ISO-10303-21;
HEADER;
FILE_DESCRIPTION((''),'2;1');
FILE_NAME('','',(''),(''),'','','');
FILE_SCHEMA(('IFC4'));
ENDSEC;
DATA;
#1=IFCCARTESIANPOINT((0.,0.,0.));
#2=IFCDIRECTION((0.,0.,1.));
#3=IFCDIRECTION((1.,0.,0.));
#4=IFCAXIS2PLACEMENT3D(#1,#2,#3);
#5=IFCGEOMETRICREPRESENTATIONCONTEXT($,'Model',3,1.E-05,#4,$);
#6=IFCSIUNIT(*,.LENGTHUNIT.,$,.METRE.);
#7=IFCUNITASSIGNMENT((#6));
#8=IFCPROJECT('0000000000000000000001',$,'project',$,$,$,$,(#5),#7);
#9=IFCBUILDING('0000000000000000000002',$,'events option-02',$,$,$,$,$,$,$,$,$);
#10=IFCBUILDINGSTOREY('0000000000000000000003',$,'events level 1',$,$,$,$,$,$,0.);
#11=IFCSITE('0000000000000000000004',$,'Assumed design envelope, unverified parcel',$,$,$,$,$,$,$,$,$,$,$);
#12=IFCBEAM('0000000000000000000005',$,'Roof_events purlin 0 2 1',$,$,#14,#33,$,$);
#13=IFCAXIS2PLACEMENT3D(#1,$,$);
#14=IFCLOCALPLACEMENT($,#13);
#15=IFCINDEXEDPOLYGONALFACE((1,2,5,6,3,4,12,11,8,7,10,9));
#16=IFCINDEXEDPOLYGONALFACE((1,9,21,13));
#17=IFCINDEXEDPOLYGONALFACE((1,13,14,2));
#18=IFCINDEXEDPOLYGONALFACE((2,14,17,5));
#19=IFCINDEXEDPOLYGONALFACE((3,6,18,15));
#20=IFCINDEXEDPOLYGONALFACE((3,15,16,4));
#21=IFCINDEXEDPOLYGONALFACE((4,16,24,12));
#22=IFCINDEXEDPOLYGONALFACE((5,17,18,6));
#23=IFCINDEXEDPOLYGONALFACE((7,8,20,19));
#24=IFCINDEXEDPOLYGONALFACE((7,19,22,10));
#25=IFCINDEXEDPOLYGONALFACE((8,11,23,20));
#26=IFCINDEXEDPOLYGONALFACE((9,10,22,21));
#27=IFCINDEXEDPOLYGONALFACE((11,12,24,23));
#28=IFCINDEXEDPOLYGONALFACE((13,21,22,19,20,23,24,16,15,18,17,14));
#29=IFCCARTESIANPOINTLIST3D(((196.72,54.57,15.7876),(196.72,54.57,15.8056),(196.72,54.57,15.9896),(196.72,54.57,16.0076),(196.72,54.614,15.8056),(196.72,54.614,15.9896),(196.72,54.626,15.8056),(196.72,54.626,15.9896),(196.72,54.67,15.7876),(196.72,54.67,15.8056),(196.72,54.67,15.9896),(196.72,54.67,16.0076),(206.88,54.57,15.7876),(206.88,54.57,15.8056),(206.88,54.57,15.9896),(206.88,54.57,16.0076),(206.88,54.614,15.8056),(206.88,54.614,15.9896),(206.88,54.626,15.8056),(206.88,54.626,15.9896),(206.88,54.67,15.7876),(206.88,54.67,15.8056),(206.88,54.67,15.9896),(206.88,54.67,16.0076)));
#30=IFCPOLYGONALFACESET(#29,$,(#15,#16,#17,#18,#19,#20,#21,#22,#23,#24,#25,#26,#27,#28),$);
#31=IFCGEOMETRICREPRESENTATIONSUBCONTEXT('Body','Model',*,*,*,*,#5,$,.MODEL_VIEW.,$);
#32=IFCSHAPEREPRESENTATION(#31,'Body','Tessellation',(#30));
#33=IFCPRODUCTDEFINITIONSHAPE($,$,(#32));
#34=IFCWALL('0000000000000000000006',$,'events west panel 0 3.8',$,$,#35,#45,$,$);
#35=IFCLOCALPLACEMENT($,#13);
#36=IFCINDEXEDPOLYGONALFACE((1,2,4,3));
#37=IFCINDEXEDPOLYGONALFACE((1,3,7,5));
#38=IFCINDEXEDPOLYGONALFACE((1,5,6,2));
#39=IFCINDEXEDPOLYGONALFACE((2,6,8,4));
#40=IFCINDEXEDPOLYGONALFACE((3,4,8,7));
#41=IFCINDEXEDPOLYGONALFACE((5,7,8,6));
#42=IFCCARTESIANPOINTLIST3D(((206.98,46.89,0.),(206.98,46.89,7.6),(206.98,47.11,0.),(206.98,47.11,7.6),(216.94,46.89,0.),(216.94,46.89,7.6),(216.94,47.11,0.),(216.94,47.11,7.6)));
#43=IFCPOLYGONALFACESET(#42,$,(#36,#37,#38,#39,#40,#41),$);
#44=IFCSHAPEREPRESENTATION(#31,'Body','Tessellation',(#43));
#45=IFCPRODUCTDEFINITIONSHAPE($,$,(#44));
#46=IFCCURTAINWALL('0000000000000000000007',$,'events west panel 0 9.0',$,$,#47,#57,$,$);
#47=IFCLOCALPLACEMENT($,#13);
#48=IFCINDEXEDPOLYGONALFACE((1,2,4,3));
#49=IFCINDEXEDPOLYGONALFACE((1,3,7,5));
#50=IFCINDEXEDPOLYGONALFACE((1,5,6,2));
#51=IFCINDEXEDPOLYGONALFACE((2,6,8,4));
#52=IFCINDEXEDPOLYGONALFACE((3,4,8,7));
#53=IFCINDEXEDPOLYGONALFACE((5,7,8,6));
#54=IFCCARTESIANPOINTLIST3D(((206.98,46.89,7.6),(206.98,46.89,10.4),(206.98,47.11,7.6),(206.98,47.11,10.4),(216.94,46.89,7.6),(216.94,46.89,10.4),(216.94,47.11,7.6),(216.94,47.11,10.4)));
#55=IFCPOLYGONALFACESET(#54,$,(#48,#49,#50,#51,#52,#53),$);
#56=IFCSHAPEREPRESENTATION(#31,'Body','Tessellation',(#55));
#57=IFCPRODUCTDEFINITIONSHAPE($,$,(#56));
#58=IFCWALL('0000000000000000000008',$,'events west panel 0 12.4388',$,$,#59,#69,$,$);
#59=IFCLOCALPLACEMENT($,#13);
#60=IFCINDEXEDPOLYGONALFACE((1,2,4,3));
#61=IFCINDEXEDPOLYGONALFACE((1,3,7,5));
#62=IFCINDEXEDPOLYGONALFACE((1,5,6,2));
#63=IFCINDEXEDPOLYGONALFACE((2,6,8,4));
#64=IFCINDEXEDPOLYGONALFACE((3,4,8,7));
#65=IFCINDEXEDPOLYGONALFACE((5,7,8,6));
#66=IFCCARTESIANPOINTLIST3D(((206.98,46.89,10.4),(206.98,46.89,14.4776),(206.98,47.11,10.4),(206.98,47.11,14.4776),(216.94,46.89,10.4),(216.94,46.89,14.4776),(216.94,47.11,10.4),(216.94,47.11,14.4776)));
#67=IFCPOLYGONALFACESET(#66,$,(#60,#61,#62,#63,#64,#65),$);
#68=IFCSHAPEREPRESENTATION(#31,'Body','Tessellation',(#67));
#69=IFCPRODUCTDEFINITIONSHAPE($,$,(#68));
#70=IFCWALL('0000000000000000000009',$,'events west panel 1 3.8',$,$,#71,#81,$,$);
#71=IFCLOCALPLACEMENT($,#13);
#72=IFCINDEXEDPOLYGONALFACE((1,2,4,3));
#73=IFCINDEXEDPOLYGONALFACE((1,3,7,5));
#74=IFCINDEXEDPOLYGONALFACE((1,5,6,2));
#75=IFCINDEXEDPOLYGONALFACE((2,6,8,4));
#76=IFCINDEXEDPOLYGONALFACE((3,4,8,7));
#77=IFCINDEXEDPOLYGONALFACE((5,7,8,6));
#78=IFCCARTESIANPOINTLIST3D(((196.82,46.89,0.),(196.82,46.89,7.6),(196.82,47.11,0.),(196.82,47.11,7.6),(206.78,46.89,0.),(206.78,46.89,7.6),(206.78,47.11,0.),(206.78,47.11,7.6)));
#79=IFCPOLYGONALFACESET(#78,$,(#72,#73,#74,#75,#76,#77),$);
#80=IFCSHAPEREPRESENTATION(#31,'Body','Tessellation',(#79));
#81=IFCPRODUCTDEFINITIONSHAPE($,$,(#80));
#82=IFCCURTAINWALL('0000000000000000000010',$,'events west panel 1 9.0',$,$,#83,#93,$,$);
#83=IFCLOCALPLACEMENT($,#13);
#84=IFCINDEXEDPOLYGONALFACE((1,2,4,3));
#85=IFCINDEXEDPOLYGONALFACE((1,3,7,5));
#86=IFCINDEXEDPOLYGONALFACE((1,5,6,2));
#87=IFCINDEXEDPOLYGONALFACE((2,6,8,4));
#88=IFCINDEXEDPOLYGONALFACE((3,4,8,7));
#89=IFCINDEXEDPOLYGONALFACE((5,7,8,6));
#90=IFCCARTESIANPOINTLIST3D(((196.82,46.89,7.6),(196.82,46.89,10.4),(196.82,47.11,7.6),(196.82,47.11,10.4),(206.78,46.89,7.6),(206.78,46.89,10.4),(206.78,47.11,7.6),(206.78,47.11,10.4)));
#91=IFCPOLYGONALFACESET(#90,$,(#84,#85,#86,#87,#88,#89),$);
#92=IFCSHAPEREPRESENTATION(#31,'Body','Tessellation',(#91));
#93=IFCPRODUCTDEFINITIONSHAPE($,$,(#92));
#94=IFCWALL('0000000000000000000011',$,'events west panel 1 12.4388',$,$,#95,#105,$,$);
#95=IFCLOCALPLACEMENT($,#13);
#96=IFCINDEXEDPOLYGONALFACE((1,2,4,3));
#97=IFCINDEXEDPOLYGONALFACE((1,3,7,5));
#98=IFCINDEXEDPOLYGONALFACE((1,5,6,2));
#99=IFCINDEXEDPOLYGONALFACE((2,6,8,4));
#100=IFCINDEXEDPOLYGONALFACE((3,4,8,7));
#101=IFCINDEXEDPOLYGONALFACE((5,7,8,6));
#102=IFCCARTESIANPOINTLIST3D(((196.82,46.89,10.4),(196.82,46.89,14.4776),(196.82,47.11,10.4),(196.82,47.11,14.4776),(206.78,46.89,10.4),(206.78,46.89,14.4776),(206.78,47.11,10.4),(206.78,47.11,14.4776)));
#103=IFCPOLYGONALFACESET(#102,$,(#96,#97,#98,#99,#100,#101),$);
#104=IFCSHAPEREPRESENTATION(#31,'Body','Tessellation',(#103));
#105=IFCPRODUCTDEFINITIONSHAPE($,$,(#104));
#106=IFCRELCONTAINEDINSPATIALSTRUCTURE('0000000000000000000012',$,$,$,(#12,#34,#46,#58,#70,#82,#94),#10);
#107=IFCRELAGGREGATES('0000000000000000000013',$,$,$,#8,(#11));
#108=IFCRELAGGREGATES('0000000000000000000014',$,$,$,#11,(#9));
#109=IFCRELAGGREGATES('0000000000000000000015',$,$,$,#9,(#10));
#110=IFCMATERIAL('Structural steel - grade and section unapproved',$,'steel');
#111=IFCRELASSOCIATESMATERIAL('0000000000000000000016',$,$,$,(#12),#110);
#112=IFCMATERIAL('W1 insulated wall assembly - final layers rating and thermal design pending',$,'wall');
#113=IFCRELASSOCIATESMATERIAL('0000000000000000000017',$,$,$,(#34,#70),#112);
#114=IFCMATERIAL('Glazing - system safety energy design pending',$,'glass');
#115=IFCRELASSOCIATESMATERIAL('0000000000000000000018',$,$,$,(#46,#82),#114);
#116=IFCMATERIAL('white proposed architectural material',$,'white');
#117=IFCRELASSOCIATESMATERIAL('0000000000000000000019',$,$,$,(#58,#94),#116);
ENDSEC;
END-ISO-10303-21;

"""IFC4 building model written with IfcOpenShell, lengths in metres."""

from ifc_helpers import new_model, si_unit, frame, origin_with_axes, place, context, subcontext, project, spatial, rectangle, i_section, extrude, material, element, save


model = new_model("IFC4")

# Units and contexts
model_context = context("Model", 3, precision=1e-05, world=origin_with_axes())
body_context = subcontext(model_context, "Body", "Model", "MODEL_VIEW")
ifc_project = project(units=[si_unit("LENGTHUNIT", "METRE")], contexts=[model_context])

# Site, building, storey
site = spatial("IfcSite", under=ifc_project, Name="Assumed design envelope, unverified parcel")
building = spatial("IfcBuilding", under=site, Name="events option-02")
storey = spatial("IfcBuildingStorey", under=building, Name="events level 1", Elevation=0.0)

# Shared definitions
ifc_material_1 = material(Name="Structural steel - grade and section unapproved", Category="steel")

# Beam
beam_1_placement = place(None, frame((206.88, 54.62, 15.8976), z_axis=(-1.0, 0.0, 0.0), x_axis=(0.0, -1.0, 0.0)))
element("IfcBeam", 1, at=beam_1_placement, inside=storey, material=ifc_material_1, Name="Roof_events purlin 0 2 1", context=body_context, shape_type="SweptSolid", body=[
    extrude(i_section(OverallWidth=0.1, OverallDepth=0.22, WebThickness=0.012, FlangeThickness=0.018, FilletRadius=0.0), origin_with_axes(), (0.0, 0.0, 1.0), 10.16),
])

# Wall
ifc_material_2 = material(Name="W1 insulated wall assembly - final layers rating and thermal design pending", Category="wall")
wall_1_placement = place(None, frame((211.96, 47.0, 0.0), z_axis=(0.0, 0.0, 1.0), x_axis=(0.0, 1.0, 0.0)))
element("IfcWall", 2, at=wall_1_placement, inside=storey, material=ifc_material_2, Name="events west panel 0 3.8", context=body_context, shape_type="SweptSolid", body=[
    extrude(rectangle(XDim=0.22, YDim=9.96), origin_with_axes(), (0.0, 0.0, 1.0), 7.6),
])

# Curtain wall
ifc_material_3 = material(Name="Glazing - system safety energy design pending", Category="glass")
curtain_wall_1_placement = place(None, frame((211.96, 47.0, 7.6), z_axis=(0.0, 0.0, 1.0), x_axis=(0.0, 1.0, 0.0)))
element("IfcCurtainWall", 3, at=curtain_wall_1_placement, inside=storey, material=ifc_material_3, Name="events west panel 0 9.0", context=body_context, shape_type="SweptSolid", body=[
    extrude(rectangle(XDim=0.22, YDim=9.96), origin_with_axes(), (0.0, 0.0, 1.0), 2.8),
])

# Walls
ifc_material_4 = material(Name="white proposed architectural material", Category="white")
wall_2_placement = place(None, frame((211.96, 47.0, 10.4), z_axis=(0.0, 0.0, 1.0), x_axis=(0.0, 1.0, 0.0)))
element("IfcWall", 4, at=wall_2_placement, inside=storey, material=ifc_material_4, Name="events west panel 0 12.4388", context=body_context, shape_type="SweptSolid", body=[
    extrude(rectangle(XDim=0.22, YDim=9.96), origin_with_axes(), (0.0, 0.0, 1.0), 4.0776),
])
wall_3_placement = place(None, frame((201.8, 47.0, 0.0), z_axis=(0.0, 0.0, 1.0), x_axis=(0.0, 1.0, 0.0)))
element("IfcWall", 5, at=wall_3_placement, inside=storey, material=ifc_material_2, Name="events west panel 1 3.8", context=body_context, shape_type="SweptSolid", body=[
    extrude(rectangle(XDim=0.22, YDim=9.96), origin_with_axes(), (0.0, 0.0, 1.0), 7.6),
])

# Curtain wall
curtain_wall_2_placement = place(None, frame((201.8, 47.0, 7.6), z_axis=(0.0, 0.0, 1.0), x_axis=(0.0, 1.0, 0.0)))
element("IfcCurtainWall", 6, at=curtain_wall_2_placement, inside=storey, material=ifc_material_3, Name="events west panel 1 9.0", context=body_context, shape_type="SweptSolid", body=[
    extrude(rectangle(XDim=0.22, YDim=9.96), origin_with_axes(), (0.0, 0.0, 1.0), 2.8),
])

# Wall
wall_4_placement = place(None, frame((201.8, 47.0, 10.4), z_axis=(0.0, 0.0, 1.0), x_axis=(0.0, 1.0, 0.0)))
element("IfcWall", 7, at=wall_4_placement, inside=storey, material=ifc_material_4, Name="events west panel 1 12.4388", context=body_context, shape_type="SweptSolid", body=[
    extrude(rectangle(XDim=0.22, YDim=9.96), origin_with_axes(), (0.0, 0.0, 1.0), 4.0776),
])

save(model, "model.ifc")
